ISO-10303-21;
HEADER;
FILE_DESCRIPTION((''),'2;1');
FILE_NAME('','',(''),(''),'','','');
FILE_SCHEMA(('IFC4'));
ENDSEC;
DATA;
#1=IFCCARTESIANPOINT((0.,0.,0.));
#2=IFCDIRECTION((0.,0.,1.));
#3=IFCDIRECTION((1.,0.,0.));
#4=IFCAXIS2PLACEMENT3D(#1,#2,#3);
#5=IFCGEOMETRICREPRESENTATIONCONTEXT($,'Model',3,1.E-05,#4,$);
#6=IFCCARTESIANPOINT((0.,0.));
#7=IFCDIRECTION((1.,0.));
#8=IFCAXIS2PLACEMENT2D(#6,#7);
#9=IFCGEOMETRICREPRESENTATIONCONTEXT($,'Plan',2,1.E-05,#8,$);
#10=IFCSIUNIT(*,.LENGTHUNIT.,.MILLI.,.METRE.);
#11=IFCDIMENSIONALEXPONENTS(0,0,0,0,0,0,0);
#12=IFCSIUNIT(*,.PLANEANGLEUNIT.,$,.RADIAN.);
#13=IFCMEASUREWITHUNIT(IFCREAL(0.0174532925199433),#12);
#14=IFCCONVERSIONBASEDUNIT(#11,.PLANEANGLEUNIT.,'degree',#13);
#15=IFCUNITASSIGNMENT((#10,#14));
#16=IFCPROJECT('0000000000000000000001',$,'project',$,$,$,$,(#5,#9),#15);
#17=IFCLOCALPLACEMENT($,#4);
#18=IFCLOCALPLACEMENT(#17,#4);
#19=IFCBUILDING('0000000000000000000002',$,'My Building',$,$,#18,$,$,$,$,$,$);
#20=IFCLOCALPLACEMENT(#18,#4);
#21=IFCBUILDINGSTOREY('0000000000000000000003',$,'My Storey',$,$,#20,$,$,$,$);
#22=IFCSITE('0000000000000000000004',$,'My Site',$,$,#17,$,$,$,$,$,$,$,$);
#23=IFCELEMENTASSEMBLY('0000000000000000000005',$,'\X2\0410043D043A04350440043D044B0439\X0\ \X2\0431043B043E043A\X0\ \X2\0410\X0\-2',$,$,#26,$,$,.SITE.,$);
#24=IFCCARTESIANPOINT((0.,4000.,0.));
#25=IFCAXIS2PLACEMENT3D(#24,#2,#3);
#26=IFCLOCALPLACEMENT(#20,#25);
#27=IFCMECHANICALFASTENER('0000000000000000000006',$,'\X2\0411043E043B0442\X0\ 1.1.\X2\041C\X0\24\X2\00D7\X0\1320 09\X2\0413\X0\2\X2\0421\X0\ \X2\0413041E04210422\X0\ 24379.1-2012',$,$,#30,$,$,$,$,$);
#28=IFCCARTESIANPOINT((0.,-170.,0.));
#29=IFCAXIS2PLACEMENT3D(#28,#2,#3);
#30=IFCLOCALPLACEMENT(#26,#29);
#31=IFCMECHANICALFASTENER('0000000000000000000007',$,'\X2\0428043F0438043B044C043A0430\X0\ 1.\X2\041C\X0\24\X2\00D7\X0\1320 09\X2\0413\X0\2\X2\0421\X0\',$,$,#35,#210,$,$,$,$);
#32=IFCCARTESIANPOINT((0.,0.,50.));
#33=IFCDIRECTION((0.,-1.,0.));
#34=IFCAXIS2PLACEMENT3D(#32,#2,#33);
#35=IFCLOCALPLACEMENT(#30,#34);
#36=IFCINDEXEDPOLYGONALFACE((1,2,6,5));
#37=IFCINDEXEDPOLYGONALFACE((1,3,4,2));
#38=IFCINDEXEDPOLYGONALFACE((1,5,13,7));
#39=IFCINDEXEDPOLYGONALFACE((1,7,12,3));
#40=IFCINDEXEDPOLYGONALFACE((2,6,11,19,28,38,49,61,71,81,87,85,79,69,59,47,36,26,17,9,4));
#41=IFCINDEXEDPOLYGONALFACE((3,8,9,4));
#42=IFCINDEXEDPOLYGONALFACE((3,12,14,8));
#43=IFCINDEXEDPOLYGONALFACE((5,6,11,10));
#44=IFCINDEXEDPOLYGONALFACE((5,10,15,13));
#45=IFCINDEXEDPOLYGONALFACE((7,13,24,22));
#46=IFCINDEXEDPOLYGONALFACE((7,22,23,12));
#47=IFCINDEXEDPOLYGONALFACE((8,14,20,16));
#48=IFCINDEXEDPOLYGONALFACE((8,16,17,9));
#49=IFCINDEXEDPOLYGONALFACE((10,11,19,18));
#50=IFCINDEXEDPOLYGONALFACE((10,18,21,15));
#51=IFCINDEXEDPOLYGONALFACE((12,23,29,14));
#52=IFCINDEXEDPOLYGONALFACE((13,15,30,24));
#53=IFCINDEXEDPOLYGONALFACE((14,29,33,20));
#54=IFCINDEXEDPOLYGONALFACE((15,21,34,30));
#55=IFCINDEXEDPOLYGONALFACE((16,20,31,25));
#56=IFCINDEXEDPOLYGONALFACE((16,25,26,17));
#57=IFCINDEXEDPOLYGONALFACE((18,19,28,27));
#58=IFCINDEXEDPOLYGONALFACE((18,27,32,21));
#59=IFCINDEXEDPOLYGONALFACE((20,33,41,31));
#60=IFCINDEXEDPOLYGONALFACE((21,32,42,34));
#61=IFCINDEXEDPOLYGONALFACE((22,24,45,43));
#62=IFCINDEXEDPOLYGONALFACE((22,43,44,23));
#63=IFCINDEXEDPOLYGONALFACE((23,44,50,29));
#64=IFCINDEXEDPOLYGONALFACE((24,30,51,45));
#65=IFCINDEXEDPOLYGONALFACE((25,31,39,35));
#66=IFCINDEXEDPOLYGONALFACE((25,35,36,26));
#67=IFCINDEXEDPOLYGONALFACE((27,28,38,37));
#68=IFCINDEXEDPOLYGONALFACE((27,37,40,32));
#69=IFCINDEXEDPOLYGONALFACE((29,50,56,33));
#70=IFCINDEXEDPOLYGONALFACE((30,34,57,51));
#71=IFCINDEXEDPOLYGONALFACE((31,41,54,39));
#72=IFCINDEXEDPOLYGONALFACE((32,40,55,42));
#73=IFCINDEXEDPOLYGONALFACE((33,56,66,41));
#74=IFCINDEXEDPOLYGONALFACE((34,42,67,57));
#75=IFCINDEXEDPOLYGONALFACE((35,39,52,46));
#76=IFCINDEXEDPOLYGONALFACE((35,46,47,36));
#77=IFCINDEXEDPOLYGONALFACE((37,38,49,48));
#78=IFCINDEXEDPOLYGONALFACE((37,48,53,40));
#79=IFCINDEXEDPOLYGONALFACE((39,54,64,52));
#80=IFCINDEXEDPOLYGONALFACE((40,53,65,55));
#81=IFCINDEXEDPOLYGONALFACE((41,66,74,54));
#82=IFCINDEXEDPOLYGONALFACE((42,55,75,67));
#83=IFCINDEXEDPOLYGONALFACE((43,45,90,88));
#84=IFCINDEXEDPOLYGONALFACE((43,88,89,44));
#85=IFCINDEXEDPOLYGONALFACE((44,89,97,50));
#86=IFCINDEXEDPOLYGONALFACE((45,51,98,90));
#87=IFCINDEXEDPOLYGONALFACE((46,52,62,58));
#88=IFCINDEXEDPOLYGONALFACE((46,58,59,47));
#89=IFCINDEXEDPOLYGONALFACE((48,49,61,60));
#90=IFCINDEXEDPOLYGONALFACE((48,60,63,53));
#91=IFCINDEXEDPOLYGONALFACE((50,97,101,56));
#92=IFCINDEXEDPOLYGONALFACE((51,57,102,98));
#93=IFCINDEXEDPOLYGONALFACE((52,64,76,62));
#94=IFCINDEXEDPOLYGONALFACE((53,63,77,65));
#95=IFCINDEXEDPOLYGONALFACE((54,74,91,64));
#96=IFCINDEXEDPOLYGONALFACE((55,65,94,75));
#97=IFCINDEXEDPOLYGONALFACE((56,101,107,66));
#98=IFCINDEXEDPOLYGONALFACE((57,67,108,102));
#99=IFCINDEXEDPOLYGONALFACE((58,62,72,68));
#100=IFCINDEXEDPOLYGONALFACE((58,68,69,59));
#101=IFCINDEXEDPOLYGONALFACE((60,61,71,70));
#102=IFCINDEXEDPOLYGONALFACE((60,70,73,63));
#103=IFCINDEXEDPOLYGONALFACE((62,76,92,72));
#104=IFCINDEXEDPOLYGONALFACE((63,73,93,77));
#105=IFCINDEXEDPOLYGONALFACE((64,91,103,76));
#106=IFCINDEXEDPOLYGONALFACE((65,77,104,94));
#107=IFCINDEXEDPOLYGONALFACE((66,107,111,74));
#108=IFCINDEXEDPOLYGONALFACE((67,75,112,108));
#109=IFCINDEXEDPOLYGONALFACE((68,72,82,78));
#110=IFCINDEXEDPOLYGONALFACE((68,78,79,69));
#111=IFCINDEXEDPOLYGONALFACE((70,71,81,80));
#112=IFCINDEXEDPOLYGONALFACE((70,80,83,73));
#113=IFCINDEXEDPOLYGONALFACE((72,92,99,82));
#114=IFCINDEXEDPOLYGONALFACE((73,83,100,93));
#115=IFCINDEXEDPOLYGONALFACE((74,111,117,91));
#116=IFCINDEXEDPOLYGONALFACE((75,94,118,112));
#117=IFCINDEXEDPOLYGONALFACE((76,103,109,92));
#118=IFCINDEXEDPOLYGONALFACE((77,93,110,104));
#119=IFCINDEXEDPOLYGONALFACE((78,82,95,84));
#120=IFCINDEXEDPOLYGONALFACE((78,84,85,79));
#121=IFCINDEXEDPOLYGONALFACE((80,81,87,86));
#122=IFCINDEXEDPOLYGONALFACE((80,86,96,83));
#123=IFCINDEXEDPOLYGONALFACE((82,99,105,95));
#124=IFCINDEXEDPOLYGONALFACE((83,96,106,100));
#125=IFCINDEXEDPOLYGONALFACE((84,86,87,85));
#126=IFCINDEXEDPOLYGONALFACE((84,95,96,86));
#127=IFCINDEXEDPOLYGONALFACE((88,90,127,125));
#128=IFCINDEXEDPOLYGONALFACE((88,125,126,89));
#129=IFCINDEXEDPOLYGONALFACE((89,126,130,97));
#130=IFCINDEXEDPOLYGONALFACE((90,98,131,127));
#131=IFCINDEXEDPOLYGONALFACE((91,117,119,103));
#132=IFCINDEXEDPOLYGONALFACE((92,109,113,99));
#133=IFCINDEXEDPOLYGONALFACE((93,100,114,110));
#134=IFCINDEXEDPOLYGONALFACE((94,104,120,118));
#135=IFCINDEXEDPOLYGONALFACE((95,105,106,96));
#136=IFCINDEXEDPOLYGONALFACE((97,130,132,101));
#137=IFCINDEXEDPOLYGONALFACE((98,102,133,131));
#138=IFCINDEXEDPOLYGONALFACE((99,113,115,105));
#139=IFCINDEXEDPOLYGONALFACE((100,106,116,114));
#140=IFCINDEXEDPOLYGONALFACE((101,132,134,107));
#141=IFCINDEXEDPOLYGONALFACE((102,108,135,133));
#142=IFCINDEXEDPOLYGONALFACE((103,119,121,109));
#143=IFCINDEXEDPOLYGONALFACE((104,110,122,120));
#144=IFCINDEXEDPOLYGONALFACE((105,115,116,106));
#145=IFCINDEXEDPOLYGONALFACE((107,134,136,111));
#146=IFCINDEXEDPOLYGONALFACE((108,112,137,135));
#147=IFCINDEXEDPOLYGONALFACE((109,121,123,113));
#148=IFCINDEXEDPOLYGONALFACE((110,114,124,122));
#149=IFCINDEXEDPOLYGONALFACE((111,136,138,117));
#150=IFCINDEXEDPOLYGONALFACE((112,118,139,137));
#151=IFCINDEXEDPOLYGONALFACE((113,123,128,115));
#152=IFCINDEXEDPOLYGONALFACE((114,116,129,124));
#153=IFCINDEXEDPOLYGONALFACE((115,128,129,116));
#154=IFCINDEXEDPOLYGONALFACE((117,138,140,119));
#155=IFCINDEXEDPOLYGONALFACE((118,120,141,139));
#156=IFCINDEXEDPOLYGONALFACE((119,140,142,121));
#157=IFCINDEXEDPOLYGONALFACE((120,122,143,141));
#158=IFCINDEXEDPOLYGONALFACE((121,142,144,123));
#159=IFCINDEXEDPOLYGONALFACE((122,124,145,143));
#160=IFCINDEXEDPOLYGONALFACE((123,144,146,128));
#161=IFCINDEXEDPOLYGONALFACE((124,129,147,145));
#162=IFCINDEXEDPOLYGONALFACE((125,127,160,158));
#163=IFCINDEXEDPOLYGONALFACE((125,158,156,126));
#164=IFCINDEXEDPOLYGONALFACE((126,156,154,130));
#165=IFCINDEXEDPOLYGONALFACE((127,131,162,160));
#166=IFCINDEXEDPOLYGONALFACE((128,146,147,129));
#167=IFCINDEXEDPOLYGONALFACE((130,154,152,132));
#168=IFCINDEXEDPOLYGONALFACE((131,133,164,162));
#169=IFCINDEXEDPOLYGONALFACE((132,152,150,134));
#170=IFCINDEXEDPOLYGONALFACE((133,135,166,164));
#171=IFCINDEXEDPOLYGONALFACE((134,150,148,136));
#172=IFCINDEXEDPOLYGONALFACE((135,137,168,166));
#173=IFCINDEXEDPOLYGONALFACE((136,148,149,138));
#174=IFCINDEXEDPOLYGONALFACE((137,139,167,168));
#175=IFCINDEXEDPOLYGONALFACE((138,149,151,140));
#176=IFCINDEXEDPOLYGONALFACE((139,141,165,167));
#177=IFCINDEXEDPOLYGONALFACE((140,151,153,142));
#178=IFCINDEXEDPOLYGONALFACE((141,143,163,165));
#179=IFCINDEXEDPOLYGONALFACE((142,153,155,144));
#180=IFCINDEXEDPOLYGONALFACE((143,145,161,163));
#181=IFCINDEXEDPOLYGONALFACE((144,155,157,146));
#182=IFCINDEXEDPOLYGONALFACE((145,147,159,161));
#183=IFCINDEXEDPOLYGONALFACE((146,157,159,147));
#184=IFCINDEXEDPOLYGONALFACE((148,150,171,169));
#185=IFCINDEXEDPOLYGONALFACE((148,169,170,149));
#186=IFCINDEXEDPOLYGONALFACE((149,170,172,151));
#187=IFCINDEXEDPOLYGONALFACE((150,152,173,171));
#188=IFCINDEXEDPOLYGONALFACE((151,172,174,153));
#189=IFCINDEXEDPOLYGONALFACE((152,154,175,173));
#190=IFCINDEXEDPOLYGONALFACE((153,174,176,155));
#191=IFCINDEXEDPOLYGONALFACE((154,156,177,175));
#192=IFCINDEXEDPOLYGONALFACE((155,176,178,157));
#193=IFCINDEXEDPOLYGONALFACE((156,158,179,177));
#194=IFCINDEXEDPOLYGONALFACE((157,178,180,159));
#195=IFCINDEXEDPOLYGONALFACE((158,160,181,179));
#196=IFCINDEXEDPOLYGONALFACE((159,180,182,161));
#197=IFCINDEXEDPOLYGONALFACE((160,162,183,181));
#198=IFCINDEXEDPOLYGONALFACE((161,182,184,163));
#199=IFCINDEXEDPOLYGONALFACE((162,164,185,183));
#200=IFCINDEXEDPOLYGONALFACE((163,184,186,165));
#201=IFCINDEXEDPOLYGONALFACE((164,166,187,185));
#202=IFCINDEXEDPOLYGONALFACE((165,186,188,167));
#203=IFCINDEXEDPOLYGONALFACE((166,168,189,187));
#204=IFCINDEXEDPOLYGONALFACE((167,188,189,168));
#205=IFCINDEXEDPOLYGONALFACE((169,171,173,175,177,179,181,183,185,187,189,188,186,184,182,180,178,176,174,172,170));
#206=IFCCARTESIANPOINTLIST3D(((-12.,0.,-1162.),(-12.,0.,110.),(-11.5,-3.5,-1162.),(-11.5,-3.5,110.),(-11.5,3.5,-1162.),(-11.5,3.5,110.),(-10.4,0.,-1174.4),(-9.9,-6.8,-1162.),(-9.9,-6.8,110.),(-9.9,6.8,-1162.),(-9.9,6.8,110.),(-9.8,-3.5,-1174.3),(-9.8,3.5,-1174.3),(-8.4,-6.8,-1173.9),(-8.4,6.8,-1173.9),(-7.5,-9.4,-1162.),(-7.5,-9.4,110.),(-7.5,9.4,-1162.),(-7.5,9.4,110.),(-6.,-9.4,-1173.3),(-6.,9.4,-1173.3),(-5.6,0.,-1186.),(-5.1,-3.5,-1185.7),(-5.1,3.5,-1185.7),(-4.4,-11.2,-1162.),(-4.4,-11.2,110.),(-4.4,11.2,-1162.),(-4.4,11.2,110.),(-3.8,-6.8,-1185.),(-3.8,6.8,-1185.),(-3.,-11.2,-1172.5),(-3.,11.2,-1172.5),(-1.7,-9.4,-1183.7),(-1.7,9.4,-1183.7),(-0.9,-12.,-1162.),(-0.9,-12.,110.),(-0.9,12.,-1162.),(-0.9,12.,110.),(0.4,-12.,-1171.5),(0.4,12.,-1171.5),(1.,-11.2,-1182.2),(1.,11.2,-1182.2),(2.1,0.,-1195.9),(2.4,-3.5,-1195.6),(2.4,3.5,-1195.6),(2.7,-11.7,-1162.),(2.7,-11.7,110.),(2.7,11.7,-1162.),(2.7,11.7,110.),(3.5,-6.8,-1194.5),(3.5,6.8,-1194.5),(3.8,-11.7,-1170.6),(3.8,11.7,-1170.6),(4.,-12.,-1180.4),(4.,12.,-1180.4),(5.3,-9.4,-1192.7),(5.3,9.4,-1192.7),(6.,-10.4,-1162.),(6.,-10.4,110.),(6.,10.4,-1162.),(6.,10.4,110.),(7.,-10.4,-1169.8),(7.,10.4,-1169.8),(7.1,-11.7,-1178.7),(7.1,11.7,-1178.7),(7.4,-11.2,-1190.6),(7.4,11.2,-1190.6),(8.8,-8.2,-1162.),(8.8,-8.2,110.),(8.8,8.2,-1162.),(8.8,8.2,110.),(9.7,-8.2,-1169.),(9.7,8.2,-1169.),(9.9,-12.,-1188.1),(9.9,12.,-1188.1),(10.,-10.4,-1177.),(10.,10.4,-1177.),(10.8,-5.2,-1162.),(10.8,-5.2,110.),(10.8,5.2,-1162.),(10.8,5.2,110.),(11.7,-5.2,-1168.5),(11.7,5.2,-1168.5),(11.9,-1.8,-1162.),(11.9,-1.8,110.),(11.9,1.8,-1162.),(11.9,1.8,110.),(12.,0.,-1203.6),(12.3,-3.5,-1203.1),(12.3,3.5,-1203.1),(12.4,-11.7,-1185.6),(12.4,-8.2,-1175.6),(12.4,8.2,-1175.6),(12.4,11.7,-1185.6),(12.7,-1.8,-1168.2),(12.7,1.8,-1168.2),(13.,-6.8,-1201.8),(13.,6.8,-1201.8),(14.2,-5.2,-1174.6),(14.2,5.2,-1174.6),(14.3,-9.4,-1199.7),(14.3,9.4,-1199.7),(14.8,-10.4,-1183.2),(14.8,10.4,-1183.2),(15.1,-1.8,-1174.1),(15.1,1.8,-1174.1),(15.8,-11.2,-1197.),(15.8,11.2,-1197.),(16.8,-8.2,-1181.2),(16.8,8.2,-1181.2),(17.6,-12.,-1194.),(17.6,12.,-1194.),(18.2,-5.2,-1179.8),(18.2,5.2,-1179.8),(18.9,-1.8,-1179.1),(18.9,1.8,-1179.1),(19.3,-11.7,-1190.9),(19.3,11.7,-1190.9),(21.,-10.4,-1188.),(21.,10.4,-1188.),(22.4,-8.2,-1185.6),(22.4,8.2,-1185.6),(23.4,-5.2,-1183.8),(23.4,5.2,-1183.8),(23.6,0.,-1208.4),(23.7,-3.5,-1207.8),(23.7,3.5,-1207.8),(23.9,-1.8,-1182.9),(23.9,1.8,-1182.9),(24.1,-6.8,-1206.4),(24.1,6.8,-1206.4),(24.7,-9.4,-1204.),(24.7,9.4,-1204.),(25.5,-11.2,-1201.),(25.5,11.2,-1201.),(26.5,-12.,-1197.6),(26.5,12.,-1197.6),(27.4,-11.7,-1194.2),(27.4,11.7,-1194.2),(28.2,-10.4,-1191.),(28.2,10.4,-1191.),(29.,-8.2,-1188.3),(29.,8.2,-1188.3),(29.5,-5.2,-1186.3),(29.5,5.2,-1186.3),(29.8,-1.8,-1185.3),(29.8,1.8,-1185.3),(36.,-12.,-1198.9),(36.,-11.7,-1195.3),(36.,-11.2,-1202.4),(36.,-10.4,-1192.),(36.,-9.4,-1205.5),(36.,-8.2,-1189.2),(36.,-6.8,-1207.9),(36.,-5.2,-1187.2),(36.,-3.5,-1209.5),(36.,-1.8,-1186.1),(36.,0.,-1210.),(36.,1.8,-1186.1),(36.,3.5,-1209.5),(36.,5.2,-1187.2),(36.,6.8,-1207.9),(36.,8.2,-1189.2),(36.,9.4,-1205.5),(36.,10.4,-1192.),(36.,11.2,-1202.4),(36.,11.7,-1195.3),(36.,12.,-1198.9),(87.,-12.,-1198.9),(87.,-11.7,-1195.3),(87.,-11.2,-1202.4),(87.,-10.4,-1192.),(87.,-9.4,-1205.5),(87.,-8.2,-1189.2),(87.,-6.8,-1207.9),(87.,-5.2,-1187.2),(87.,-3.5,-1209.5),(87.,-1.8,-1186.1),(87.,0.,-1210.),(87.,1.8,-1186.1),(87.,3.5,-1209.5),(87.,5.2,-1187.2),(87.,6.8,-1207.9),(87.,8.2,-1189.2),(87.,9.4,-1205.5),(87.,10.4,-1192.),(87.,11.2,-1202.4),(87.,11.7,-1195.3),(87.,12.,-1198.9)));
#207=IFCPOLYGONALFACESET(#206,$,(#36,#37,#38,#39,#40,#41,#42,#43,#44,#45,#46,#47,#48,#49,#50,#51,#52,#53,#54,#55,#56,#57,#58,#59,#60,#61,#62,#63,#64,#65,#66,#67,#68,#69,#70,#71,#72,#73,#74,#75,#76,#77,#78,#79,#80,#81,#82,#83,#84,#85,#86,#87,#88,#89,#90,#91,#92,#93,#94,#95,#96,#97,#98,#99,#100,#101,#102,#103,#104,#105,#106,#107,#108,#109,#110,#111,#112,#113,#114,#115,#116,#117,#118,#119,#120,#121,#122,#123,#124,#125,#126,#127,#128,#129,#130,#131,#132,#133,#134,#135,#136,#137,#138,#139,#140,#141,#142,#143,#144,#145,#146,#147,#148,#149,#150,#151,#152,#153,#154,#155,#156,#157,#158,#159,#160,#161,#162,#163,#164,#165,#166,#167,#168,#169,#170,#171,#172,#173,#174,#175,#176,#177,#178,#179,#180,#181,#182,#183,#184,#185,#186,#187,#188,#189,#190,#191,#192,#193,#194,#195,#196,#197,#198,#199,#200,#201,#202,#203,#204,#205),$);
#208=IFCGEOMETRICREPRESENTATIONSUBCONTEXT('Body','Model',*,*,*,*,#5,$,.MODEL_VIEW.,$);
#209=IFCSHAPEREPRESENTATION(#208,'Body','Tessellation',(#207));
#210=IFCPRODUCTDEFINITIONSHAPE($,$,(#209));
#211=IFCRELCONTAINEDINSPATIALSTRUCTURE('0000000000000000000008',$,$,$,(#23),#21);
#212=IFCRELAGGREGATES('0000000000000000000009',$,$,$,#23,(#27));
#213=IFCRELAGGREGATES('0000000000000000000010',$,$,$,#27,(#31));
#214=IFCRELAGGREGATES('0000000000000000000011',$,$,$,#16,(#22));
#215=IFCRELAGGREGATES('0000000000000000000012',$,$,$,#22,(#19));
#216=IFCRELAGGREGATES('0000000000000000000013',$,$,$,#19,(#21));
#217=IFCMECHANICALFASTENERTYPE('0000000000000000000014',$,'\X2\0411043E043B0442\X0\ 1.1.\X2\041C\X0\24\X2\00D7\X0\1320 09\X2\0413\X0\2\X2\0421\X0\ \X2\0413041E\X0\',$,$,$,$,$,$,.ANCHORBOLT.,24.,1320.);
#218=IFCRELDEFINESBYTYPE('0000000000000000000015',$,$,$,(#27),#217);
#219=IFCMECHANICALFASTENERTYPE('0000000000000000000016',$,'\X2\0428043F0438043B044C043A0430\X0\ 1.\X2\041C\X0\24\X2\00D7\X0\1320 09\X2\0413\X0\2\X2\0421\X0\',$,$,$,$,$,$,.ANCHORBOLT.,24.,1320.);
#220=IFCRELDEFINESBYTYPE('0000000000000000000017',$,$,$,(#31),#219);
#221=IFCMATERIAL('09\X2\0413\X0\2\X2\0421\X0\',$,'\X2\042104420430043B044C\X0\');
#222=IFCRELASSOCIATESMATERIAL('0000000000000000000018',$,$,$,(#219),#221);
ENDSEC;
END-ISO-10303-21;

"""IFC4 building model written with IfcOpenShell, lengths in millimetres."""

from ifc_helpers import new_model, entity, si_unit, converted_unit, frame, origin_with_axes, origin_2d_with_axis, place, context, subcontext, project, spatial, source, transform, mapped, material, type_object, type_shapes, element, aggregate, save


model = new_model("IFC4")

# Units and contexts
model_context = context("Model", 3, precision=1e-05, world=origin_with_axes())
plan_context = context("Plan", 2, precision=1e-05, world=origin_2d_with_axis())
body_context = subcontext(model_context, "Body", "Model", "MODEL_VIEW")
ifc_project = project(units=[si_unit("LENGTHUNIT", "METRE", prefix="MILLI"), converted_unit("PLANEANGLEUNIT", "degree", entity("IfcReal", 0.0174532925199433), si_unit("PLANEANGLEUNIT", "RADIAN"), dimensions=[0, 0, 0, 0, 0, 0, 0])], contexts=[model_context, plan_context])

# Site, building, storey
site_placement = place(None, origin_with_axes())
site = spatial("IfcSite", under=ifc_project, at=site_placement, Name="My Site")
building_placement = place(site_placement, origin_with_axes())
building = spatial("IfcBuilding", under=site, at=building_placement, Name="My Building")
storey_placement = place(building_placement, origin_with_axes())
storey = spatial("IfcBuildingStorey", under=building, at=storey_placement, Name="My Storey")

# Shared definitions
placement_1 = place(storey_placement, frame((0.0, 4000.0, 0.0), z_axis=(0.0, 0.0, 1.0), x_axis=(1.0, 0.0, 0.0)))

# Element assembly, mechanical fasteners
ifc_material_1 = material(Name="09Г2С", Category="Сталь")
mechanical_fastener_type_1 = type_object("IfcMechanicalFastenerType", Name="Шпилька 1.М24×1320 09Г2С", NominalDiameter=24.0, NominalLength=1320.0, PredefinedType="ANCHORBOLT", material=ifc_material_1)
shared_shape_1 = source(frame((0.0, 0.0, 110.0), z_axis=(0.0, 0.0, 1.0), x_axis=(1.0, 0.0, 0.0)), body_context, "Body", "AdvancedSweptSolid", [
    entity("IfcSweptDiskSolid", entity("IfcIndexedPolyCurve", entity("IfcCartesianPointList3D", [[0.0, 0.0, 0.0], [0.0, 0.0, -1272.0], [10.5, 0.0, -1297.5], [36.0, 0.0, -1308.0], [87.0, 0.0, -1308.0]]), [entity("IfcLineIndex", [1, 2]), entity("IfcArcIndex", [2, 3, 4]), entity("IfcLineIndex", [4, 5])]), 12.0),
])
type_shapes(mechanical_fastener_type_1, [shared_shape_1])
mechanical_fastener_type_2 = type_object("IfcMechanicalFastenerType", Name="Болт 1.1.М24×1320 09Г2С ГО", NominalDiameter=24.0, NominalLength=1320.0, PredefinedType="ANCHORBOLT")
assembly_1 = element("IfcElementAssembly", 1, at=placement_1, inside=storey, Name="Анкерный блок А-2", AssemblyPlace="SITE")
mechanical_fastener_1_placement = place(placement_1, frame((0.0, -170.0, 0.0), z_axis=(0.0, 0.0, 1.0), x_axis=(1.0, 0.0, 0.0)))
mechanical_fastener_1 = element("IfcMechanicalFastener", 2, at=mechanical_fastener_1_placement, type_object=mechanical_fastener_type_2, Name="Болт 1.1.М24×1320 09Г2С ГОСТ 24379.1-2012")
mechanical_fastener_2_placement = place(mechanical_fastener_1_placement, frame((0.0, 0.0, 50.0), z_axis=(0.0, 0.0, 1.0), x_axis=(0.0, -1.0, 0.0)))
mechanical_fastener_2 = element("IfcMechanicalFastener", 3, at=mechanical_fastener_2_placement, type_object=mechanical_fastener_type_1, Name="Шпилька 1.М24×1320 09Г2С", context=body_context, shape_type="MappedRepresentation", body=[
    mapped(shared_shape_1, transform((0.0, 0.0, 0.0), x_axis=(1.0, 0.0, 0.0), y_axis=(0.0, 1.0, 0.0), z_axis=(0.0, 0.0, 1.0), scale=1.0)),
])
aggregate(assembly_1, [mechanical_fastener_1])

aggregate(mechanical_fastener_1, [mechanical_fastener_2])

save(model, "model.ifc")
